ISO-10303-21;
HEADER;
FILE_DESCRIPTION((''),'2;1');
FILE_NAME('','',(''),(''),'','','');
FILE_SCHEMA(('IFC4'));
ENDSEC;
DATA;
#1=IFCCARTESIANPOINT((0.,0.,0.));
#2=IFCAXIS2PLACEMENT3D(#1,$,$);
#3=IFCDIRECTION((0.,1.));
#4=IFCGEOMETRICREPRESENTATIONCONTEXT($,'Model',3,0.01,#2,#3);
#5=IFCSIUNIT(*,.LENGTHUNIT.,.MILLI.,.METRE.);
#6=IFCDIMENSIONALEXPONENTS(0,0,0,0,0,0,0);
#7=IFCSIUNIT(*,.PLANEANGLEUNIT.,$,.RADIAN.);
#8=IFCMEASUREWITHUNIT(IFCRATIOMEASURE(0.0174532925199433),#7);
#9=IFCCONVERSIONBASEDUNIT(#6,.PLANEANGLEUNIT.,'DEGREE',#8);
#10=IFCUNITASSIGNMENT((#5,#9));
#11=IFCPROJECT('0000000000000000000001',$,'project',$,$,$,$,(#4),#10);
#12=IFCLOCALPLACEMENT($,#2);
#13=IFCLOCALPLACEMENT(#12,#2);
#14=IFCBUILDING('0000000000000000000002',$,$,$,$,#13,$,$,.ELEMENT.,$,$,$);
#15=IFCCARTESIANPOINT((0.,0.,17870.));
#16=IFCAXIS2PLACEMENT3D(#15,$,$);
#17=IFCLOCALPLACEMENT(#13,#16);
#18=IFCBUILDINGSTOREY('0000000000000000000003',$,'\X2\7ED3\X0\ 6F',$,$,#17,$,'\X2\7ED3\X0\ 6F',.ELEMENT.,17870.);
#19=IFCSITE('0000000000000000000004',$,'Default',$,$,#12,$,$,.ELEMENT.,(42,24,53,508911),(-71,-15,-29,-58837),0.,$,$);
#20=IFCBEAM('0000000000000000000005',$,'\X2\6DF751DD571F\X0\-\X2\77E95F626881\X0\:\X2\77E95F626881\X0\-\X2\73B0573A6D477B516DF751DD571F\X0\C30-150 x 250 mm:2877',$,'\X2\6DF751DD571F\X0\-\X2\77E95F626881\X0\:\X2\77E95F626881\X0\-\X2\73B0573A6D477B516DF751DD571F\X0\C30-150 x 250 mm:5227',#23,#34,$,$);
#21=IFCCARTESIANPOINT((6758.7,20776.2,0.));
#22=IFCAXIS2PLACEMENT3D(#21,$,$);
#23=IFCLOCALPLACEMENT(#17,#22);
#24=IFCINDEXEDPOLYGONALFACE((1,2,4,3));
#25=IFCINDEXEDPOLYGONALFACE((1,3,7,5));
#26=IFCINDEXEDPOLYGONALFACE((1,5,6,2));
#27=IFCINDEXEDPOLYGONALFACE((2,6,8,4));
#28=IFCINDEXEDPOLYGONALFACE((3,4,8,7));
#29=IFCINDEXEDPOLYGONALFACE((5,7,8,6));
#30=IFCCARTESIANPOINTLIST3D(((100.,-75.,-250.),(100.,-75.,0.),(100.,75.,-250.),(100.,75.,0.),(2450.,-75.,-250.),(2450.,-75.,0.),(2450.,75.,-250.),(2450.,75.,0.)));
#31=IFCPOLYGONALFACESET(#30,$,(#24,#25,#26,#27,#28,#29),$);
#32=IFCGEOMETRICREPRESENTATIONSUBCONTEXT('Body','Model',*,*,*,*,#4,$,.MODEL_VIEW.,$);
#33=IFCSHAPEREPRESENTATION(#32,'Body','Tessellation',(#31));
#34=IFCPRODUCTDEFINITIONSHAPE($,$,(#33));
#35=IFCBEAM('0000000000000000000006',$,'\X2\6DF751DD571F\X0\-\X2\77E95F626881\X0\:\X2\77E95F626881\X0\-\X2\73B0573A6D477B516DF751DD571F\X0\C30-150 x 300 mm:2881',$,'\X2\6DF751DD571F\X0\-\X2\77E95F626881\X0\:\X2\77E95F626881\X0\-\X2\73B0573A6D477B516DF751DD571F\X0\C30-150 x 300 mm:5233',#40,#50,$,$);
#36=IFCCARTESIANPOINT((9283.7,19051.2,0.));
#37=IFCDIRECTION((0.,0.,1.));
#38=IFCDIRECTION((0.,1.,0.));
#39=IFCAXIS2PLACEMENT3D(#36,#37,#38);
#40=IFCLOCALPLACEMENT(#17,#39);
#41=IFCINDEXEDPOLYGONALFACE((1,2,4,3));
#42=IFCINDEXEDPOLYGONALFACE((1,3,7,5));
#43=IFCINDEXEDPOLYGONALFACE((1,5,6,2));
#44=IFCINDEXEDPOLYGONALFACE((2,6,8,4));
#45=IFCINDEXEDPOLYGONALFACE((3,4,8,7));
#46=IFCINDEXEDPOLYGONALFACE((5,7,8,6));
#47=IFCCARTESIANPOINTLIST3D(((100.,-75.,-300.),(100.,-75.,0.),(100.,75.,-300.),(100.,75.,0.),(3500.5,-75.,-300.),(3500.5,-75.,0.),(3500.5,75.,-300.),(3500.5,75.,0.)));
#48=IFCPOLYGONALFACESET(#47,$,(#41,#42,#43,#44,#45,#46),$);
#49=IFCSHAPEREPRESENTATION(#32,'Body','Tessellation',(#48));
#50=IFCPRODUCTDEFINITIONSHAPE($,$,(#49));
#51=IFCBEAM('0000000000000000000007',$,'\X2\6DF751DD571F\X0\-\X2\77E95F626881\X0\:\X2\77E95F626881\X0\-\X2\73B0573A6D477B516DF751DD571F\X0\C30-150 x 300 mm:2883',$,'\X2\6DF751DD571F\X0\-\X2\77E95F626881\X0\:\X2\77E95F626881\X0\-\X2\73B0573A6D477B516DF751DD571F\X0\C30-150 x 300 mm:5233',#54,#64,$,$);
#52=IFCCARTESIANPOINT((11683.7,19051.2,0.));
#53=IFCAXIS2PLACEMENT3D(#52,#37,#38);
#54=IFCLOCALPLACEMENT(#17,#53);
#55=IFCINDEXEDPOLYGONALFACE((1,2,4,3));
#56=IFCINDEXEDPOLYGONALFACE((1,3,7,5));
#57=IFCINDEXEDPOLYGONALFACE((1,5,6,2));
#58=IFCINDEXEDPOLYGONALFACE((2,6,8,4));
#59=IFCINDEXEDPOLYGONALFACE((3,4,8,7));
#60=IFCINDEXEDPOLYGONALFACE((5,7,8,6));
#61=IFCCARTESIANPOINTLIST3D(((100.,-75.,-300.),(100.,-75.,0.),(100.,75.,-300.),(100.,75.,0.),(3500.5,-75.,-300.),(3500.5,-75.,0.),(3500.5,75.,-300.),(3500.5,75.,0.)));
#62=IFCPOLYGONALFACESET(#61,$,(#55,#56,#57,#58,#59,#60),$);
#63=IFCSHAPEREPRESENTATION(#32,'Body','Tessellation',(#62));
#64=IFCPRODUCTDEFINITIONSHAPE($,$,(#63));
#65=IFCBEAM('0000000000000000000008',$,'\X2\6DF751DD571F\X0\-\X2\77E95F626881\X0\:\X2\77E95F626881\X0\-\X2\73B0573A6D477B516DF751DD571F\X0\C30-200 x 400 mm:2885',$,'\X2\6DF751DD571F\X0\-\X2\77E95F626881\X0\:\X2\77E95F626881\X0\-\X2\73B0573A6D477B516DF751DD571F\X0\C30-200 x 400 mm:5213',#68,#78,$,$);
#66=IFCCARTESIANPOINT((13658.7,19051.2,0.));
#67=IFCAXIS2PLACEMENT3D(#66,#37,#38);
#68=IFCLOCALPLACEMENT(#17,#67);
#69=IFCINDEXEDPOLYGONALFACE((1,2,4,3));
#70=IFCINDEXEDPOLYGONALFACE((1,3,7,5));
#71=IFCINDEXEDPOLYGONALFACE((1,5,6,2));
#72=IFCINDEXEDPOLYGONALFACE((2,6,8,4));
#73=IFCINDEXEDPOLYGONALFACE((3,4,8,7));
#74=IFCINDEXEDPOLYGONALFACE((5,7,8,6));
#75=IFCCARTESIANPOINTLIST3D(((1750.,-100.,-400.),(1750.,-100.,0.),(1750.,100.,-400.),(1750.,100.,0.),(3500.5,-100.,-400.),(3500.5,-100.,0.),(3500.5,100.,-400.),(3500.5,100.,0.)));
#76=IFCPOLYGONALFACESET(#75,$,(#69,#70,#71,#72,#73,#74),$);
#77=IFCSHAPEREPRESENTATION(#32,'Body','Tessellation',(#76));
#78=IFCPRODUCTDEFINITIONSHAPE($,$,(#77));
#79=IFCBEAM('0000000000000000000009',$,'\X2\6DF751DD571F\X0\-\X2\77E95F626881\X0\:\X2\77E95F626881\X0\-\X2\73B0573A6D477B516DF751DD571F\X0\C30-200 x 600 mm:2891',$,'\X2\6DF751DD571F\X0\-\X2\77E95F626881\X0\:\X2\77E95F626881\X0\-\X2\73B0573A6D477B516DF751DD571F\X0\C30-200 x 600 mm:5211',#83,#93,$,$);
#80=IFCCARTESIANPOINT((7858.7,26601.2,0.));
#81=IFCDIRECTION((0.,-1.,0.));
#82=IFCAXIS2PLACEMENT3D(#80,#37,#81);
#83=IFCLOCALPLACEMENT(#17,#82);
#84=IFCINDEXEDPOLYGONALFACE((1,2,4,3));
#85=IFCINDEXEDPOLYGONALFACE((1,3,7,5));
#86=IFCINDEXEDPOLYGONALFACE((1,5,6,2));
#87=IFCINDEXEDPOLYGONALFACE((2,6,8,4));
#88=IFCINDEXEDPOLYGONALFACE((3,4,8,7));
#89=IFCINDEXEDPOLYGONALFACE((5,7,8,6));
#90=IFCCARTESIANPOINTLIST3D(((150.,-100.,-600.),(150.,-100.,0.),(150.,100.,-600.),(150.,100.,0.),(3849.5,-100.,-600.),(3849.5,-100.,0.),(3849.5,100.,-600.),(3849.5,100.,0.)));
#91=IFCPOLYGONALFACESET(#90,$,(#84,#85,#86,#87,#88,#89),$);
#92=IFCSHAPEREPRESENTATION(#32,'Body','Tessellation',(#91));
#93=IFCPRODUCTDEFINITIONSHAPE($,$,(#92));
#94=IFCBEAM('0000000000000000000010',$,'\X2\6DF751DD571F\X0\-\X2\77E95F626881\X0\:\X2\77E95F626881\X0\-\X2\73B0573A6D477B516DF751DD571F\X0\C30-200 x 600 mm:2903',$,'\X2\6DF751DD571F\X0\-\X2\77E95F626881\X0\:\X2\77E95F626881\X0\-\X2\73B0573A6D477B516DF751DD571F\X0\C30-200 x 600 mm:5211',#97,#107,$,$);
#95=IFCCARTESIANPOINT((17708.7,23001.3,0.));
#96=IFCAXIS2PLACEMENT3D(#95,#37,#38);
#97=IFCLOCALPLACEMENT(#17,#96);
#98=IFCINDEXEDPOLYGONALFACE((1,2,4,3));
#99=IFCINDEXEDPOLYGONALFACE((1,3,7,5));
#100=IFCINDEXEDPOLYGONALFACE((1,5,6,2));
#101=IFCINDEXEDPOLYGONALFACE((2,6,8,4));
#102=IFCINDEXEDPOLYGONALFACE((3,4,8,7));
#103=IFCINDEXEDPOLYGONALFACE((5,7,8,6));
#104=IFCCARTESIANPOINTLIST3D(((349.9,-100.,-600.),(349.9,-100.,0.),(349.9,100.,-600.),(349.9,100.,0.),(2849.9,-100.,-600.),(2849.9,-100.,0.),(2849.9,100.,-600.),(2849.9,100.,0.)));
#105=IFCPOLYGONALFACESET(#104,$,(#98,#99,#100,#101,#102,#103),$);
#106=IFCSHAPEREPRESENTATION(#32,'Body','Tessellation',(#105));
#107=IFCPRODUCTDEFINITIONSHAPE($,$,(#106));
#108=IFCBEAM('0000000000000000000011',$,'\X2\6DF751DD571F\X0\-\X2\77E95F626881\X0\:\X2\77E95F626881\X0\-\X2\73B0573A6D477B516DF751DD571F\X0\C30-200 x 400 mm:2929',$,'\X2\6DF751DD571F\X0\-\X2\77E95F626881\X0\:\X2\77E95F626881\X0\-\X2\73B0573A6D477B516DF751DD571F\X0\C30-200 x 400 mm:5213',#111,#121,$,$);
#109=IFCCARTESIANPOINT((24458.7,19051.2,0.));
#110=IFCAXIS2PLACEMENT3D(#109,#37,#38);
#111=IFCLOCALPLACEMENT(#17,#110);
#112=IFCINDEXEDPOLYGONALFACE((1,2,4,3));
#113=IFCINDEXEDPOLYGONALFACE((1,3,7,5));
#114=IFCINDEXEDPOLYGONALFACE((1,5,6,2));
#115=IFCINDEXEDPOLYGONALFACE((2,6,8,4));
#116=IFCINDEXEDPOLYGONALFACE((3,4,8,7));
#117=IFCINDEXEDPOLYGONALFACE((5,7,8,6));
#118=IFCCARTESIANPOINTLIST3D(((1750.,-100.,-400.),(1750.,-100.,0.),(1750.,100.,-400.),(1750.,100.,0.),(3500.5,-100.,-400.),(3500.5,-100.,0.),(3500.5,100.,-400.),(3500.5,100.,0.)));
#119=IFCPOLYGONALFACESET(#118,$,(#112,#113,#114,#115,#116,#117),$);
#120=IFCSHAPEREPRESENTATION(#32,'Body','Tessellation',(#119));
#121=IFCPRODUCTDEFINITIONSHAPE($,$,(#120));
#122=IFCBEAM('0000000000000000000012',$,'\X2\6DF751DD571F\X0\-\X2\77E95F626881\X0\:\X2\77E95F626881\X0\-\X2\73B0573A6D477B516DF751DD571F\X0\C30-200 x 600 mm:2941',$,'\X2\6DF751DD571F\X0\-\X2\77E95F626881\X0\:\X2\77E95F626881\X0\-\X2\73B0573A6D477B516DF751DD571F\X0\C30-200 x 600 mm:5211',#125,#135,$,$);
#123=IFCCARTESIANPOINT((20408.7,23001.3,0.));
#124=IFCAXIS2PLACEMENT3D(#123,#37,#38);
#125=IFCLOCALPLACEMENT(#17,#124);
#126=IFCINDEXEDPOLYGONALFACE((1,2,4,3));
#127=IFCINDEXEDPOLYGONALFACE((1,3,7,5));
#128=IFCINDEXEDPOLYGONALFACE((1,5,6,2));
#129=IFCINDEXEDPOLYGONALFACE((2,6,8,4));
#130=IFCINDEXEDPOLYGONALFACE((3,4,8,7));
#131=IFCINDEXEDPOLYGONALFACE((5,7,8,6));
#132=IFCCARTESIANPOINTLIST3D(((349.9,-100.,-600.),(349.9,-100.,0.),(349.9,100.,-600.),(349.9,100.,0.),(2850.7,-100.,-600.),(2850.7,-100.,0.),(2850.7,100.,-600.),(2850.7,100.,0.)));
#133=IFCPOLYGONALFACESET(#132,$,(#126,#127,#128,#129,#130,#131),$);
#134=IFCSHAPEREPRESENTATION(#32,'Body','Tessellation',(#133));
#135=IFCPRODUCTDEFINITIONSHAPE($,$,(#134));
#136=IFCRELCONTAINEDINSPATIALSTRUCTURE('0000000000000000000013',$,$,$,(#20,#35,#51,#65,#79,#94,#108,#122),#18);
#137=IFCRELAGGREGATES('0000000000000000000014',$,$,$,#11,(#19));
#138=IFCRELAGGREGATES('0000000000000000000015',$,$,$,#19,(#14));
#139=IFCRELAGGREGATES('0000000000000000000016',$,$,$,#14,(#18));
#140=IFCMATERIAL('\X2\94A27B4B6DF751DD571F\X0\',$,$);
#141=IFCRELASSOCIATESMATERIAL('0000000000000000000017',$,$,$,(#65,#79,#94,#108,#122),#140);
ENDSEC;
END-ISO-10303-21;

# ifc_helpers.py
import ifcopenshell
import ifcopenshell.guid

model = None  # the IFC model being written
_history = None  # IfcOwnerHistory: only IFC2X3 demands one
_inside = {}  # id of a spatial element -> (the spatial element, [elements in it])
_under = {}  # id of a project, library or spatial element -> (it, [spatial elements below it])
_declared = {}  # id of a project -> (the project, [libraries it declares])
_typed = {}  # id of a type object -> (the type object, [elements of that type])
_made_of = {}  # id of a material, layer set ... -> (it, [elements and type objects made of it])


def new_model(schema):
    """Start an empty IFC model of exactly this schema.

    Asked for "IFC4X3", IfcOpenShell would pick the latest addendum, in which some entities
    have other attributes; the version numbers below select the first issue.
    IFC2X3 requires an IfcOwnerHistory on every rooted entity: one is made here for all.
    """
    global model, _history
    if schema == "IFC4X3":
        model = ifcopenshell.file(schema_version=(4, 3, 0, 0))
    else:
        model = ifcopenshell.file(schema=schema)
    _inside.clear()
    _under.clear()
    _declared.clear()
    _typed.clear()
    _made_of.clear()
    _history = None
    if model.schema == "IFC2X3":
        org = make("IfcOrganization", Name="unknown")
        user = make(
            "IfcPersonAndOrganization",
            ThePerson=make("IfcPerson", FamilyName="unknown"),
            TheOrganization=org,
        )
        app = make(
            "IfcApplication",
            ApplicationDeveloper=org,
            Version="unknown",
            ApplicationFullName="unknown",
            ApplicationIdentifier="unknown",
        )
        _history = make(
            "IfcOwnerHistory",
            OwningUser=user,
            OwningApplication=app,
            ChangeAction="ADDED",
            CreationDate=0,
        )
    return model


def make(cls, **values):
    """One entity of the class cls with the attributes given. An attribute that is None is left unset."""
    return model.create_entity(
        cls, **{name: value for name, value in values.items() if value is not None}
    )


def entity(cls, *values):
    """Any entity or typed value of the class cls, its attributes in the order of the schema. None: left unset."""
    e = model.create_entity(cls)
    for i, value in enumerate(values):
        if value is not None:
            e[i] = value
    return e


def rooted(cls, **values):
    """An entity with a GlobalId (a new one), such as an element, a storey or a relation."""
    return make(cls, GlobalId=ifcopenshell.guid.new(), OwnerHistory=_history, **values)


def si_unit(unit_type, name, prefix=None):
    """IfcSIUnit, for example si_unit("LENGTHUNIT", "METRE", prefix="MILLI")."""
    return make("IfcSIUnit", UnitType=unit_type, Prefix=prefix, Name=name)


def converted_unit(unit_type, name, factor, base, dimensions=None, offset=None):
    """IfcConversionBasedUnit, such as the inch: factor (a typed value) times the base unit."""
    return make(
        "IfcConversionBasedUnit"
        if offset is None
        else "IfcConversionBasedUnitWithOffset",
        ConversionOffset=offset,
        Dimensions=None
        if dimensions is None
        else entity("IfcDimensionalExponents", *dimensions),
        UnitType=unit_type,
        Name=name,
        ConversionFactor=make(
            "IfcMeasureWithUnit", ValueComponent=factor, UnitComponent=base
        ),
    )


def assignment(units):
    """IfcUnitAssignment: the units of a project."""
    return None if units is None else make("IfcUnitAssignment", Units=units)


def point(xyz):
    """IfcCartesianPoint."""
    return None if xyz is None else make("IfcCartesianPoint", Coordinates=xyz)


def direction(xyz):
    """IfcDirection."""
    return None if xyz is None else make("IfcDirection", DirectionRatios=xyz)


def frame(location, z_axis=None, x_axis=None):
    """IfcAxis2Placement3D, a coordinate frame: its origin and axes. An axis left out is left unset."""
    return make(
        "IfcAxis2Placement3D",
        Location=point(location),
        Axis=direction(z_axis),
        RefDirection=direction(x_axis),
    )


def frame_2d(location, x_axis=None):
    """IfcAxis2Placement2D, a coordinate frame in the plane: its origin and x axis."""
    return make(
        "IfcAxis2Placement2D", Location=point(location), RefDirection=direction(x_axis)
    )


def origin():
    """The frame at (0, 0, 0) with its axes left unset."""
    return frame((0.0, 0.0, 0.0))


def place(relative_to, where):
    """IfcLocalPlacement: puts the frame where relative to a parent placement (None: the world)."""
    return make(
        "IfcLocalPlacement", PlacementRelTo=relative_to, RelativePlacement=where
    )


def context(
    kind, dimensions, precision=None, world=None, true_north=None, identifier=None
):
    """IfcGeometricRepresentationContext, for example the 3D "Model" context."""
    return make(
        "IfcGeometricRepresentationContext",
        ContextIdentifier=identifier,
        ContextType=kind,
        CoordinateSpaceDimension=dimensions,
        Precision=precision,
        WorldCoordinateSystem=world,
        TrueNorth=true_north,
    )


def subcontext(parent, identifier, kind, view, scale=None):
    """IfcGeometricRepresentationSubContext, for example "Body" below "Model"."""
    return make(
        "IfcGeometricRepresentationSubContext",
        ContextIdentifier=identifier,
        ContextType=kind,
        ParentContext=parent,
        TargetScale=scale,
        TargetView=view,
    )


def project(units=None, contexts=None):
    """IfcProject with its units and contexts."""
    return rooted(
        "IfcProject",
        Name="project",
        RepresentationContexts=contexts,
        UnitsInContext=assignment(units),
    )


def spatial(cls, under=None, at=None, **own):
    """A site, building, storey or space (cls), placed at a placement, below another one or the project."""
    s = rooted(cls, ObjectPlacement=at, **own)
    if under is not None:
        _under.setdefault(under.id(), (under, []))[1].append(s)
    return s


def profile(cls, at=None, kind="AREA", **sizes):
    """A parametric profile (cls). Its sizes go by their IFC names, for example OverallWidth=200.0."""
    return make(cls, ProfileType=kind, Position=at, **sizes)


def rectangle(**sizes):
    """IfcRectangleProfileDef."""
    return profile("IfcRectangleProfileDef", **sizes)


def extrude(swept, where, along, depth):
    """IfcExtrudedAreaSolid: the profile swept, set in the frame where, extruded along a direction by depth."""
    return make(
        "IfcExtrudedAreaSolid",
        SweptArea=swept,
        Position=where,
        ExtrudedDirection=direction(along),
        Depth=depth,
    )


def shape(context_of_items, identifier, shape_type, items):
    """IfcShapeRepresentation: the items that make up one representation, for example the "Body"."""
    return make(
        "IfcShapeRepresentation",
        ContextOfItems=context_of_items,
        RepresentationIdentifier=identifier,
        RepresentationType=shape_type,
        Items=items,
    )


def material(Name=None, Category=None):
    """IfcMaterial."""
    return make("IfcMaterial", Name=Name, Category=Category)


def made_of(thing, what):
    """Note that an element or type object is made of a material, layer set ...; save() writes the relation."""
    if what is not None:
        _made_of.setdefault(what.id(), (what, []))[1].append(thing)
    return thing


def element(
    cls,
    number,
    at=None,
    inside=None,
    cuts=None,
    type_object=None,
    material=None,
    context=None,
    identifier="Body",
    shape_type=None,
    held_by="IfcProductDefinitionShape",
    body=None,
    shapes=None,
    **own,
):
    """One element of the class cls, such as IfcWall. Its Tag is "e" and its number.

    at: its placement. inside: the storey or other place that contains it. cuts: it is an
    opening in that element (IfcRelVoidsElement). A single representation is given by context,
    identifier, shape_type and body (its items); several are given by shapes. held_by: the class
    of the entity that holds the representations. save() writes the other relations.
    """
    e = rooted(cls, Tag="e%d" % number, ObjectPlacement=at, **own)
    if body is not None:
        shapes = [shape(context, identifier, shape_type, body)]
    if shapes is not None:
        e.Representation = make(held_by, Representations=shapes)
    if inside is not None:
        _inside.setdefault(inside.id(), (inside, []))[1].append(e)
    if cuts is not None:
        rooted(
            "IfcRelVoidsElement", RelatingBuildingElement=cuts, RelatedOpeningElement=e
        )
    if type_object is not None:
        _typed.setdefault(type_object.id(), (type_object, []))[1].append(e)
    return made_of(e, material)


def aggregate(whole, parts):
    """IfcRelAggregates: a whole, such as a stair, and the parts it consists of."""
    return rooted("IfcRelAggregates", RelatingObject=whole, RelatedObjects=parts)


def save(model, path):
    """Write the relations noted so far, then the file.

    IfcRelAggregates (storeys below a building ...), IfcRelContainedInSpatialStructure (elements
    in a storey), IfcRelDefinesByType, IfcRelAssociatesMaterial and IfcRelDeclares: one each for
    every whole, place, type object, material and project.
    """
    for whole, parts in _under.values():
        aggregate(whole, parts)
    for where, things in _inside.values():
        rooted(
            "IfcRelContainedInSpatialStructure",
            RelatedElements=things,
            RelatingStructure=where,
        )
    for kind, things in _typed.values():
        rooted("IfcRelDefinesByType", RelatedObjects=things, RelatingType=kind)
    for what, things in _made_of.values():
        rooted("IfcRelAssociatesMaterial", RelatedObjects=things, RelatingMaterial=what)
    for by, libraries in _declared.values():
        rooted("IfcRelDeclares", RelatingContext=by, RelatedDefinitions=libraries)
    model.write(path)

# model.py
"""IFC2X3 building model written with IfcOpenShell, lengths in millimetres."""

from ifc_helpers import new_model, entity, si_unit, converted_unit, direction, frame, frame_2d, origin, place, context, subcontext, project, spatial, rectangle, extrude, material, element, save


model = new_model("IFC2X3")

# Units and contexts
model_context = context("Model", 3, precision=0.01, world=origin(), true_north=direction((0.0, 1.0)))
body_context = subcontext(model_context, "Body", "Model", "MODEL_VIEW")
ifc_project = project(units=[si_unit("LENGTHUNIT", "METRE", prefix="MILLI"), converted_unit("PLANEANGLEUNIT", "DEGREE", entity("IfcRatioMeasure", 0.0174532925199433), si_unit("PLANEANGLEUNIT", "RADIAN"), dimensions=[0, 0, 0, 0, 0, 0, 0])], contexts=[model_context])

# Site, building, storey
site_placement = place(None, origin())
site = spatial("IfcSite", under=ifc_project, at=site_placement, Name="Default", CompositionType="ELEMENT", RefLatitude=(42, 24, 53, 508911), RefLongitude=(-71, -15, -29, -58837), RefElevation=0.0)
building_placement = place(site_placement, origin())
building = spatial("IfcBuilding", under=site, at=building_placement, CompositionType="ELEMENT")
storey_placement = place(building_placement, frame((0.0, 0.0, 17870.0)))
storey = spatial("IfcBuildingStorey", under=building, at=storey_placement, Name="结 6F", LongName="结 6F", CompositionType="ELEMENT", Elevation=17870.0)

# Beams
beam_1_placement = place(storey_placement, frame((6758.7, 20776.2, 0.0)))
element("IfcBeam", 1, at=beam_1_placement, inside=storey, Name="混凝土-矩形梁:矩形梁-现场浇筑混凝土C30-150 x 250 mm:2877", ObjectType="混凝土-矩形梁:矩形梁-现场浇筑混凝土C30-150 x 250 mm:5227", context=body_context, shape_type="SweptSolid", body=[
    extrude(rectangle(XDim=250.0, YDim=150.0, at=frame_2d((0.0, 0.0), x_axis=(1.0, 0.0))), frame((100.0, 0.0, -125.0), z_axis=(1.0, 0.0, 0.0), x_axis=(0.0, 0.0, -1.0)), (0.0, 0.0, 1.0), 2350.0),
])
beam_2_placement = place(storey_placement, frame((9283.7, 19051.2, 0.0), z_axis=(0.0, 0.0, 1.0), x_axis=(0.0, 1.0, 0.0)))
element("IfcBeam", 2, at=beam_2_placement, inside=storey, Name="混凝土-矩形梁:矩形梁-现场浇筑混凝土C30-150 x 300 mm:2881", ObjectType="混凝土-矩形梁:矩形梁-现场浇筑混凝土C30-150 x 300 mm:5233", context=body_context, shape_type="SweptSolid", body=[
    extrude(rectangle(XDim=300.0, YDim=150.0, at=frame_2d((0.0, 0.0), x_axis=(1.0, 0.0))), frame((100.0, 0.0, -150.0), z_axis=(1.0, 0.0, 0.0), x_axis=(0.0, 0.0, -1.0)), (0.0, 0.0, 1.0), 3400.5),
])
beam_3_placement = place(storey_placement, frame((11683.7, 19051.2, 0.0), z_axis=(0.0, 0.0, 1.0), x_axis=(0.0, 1.0, 0.0)))
element("IfcBeam", 3, at=beam_3_placement, inside=storey, Name="混凝土-矩形梁:矩形梁-现场浇筑混凝土C30-150 x 300 mm:2883", ObjectType="混凝土-矩形梁:矩形梁-现场浇筑混凝土C30-150 x 300 mm:5233", context=body_context, shape_type="SweptSolid", body=[
    extrude(rectangle(XDim=300.0, YDim=150.0, at=frame_2d((0.0, 0.0), x_axis=(1.0, 0.0))), frame((100.0, 0.0, -150.0), z_axis=(1.0, 0.0, 0.0), x_axis=(0.0, 0.0, -1.0)), (0.0, 0.0, 1.0), 3400.5),
])
ifc_material = material(Name="钢筋混凝土")
beam_4_placement = place(storey_placement, frame((13658.7, 19051.2, 0.0), z_axis=(0.0, 0.0, 1.0), x_axis=(0.0, 1.0, 0.0)))
element("IfcBeam", 4, at=beam_4_placement, inside=storey, material=ifc_material, Name="混凝土-矩形梁:矩形梁-现场浇筑混凝土C30-200 x 400 mm:2885", ObjectType="混凝土-矩形梁:矩形梁-现场浇筑混凝土C30-200 x 400 mm:5213", context=body_context, shape_type="SweptSolid", body=[
    extrude(rectangle(XDim=400.0, YDim=200.0, at=frame_2d((0.0, 0.0), x_axis=(1.0, 0.0))), frame((1750.0, 0.0, -200.0), z_axis=(1.0, 0.0, 0.0), x_axis=(0.0, 0.0, -1.0)), (0.0, 0.0, 1.0), 1750.5),
])
beam_5_placement = place(storey_placement, frame((7858.7, 26601.2, 0.0), z_axis=(0.0, 0.0, 1.0), x_axis=(0.0, -1.0, 0.0)))
element("IfcBeam", 5, at=beam_5_placement, inside=storey, material=ifc_material, Name="混凝土-矩形梁:矩形梁-现场浇筑混凝土C30-200 x 600 mm:2891", ObjectType="混凝土-矩形梁:矩形梁-现场浇筑混凝土C30-200 x 600 mm:5211", context=body_context, shape_type="SweptSolid", body=[
    extrude(rectangle(XDim=600.0, YDim=200.0, at=frame_2d((0.0, 0.0), x_axis=(1.0, 0.0))), frame((150.0, 0.0, -300.0), z_axis=(1.0, 0.0, 0.0), x_axis=(0.0, 0.0, -1.0)), (0.0, 0.0, 1.0), 3699.5),
])
beam_6_placement = place(storey_placement, frame((17708.7, 23001.3, 0.0), z_axis=(0.0, 0.0, 1.0), x_axis=(0.0, 1.0, 0.0)))
element("IfcBeam", 6, at=beam_6_placement, inside=storey, material=ifc_material, Name="混凝土-矩形梁:矩形梁-现场浇筑混凝土C30-200 x 600 mm:2903", ObjectType="混凝土-矩形梁:矩形梁-现场浇筑混凝土C30-200 x 600 mm:5211", context=body_context, shape_type="SweptSolid", body=[
    extrude(rectangle(XDim=600.0, YDim=200.0, at=frame_2d((0.0, 0.0), x_axis=(1.0, 0.0))), frame((349.9, 0.0, -300.0), z_axis=(1.0, 0.0, 0.0), x_axis=(0.0, 0.0, -1.0)), (0.0, 0.0, 1.0), 2500.0),
])
beam_7_placement = place(storey_placement, frame((24458.7, 19051.2, 0.0), z_axis=(0.0, 0.0, 1.0), x_axis=(0.0, 1.0, 0.0)))
element("IfcBeam", 7, at=beam_7_placement, inside=storey, material=ifc_material, Name="混凝土-矩形梁:矩形梁-现场浇筑混凝土C30-200 x 400 mm:2929", ObjectType="混凝土-矩形梁:矩形梁-现场浇筑混凝土C30-200 x 400 mm:5213", context=body_context, shape_type="SweptSolid", body=[
    extrude(rectangle(XDim=400.0, YDim=200.0, at=frame_2d((0.0, 0.0), x_axis=(1.0, 0.0))), frame((1750.0, 0.0, -200.0), z_axis=(1.0, 0.0, 0.0), x_axis=(0.0, 0.0, -1.0)), (0.0, 0.0, 1.0), 1750.5),
])
beam_8_placement = place(storey_placement, frame((20408.7, 23001.3, 0.0), z_axis=(0.0, 0.0, 1.0), x_axis=(0.0, 1.0, 0.0)))
element("IfcBeam", 8, at=beam_8_placement, inside=storey, material=ifc_material, Name="混凝土-矩形梁:矩形梁-现场浇筑混凝土C30-200 x 600 mm:2941", ObjectType="混凝土-矩形梁:矩形梁-现场浇筑混凝土C30-200 x 600 mm:5211", context=body_context, shape_type="SweptSolid", body=[
    extrude(rectangle(XDim=600.0, YDim=200.0, at=frame_2d((0.0, 0.0), x_axis=(1.0, 0.0))), frame((349.9, 0.0, -300.0), z_axis=(1.0, 0.0, 0.0), x_axis=(0.0, 0.0, -1.0)), (0.0, 0.0, 1.0), 2500.8),
])

save(model, "model.ifc")
